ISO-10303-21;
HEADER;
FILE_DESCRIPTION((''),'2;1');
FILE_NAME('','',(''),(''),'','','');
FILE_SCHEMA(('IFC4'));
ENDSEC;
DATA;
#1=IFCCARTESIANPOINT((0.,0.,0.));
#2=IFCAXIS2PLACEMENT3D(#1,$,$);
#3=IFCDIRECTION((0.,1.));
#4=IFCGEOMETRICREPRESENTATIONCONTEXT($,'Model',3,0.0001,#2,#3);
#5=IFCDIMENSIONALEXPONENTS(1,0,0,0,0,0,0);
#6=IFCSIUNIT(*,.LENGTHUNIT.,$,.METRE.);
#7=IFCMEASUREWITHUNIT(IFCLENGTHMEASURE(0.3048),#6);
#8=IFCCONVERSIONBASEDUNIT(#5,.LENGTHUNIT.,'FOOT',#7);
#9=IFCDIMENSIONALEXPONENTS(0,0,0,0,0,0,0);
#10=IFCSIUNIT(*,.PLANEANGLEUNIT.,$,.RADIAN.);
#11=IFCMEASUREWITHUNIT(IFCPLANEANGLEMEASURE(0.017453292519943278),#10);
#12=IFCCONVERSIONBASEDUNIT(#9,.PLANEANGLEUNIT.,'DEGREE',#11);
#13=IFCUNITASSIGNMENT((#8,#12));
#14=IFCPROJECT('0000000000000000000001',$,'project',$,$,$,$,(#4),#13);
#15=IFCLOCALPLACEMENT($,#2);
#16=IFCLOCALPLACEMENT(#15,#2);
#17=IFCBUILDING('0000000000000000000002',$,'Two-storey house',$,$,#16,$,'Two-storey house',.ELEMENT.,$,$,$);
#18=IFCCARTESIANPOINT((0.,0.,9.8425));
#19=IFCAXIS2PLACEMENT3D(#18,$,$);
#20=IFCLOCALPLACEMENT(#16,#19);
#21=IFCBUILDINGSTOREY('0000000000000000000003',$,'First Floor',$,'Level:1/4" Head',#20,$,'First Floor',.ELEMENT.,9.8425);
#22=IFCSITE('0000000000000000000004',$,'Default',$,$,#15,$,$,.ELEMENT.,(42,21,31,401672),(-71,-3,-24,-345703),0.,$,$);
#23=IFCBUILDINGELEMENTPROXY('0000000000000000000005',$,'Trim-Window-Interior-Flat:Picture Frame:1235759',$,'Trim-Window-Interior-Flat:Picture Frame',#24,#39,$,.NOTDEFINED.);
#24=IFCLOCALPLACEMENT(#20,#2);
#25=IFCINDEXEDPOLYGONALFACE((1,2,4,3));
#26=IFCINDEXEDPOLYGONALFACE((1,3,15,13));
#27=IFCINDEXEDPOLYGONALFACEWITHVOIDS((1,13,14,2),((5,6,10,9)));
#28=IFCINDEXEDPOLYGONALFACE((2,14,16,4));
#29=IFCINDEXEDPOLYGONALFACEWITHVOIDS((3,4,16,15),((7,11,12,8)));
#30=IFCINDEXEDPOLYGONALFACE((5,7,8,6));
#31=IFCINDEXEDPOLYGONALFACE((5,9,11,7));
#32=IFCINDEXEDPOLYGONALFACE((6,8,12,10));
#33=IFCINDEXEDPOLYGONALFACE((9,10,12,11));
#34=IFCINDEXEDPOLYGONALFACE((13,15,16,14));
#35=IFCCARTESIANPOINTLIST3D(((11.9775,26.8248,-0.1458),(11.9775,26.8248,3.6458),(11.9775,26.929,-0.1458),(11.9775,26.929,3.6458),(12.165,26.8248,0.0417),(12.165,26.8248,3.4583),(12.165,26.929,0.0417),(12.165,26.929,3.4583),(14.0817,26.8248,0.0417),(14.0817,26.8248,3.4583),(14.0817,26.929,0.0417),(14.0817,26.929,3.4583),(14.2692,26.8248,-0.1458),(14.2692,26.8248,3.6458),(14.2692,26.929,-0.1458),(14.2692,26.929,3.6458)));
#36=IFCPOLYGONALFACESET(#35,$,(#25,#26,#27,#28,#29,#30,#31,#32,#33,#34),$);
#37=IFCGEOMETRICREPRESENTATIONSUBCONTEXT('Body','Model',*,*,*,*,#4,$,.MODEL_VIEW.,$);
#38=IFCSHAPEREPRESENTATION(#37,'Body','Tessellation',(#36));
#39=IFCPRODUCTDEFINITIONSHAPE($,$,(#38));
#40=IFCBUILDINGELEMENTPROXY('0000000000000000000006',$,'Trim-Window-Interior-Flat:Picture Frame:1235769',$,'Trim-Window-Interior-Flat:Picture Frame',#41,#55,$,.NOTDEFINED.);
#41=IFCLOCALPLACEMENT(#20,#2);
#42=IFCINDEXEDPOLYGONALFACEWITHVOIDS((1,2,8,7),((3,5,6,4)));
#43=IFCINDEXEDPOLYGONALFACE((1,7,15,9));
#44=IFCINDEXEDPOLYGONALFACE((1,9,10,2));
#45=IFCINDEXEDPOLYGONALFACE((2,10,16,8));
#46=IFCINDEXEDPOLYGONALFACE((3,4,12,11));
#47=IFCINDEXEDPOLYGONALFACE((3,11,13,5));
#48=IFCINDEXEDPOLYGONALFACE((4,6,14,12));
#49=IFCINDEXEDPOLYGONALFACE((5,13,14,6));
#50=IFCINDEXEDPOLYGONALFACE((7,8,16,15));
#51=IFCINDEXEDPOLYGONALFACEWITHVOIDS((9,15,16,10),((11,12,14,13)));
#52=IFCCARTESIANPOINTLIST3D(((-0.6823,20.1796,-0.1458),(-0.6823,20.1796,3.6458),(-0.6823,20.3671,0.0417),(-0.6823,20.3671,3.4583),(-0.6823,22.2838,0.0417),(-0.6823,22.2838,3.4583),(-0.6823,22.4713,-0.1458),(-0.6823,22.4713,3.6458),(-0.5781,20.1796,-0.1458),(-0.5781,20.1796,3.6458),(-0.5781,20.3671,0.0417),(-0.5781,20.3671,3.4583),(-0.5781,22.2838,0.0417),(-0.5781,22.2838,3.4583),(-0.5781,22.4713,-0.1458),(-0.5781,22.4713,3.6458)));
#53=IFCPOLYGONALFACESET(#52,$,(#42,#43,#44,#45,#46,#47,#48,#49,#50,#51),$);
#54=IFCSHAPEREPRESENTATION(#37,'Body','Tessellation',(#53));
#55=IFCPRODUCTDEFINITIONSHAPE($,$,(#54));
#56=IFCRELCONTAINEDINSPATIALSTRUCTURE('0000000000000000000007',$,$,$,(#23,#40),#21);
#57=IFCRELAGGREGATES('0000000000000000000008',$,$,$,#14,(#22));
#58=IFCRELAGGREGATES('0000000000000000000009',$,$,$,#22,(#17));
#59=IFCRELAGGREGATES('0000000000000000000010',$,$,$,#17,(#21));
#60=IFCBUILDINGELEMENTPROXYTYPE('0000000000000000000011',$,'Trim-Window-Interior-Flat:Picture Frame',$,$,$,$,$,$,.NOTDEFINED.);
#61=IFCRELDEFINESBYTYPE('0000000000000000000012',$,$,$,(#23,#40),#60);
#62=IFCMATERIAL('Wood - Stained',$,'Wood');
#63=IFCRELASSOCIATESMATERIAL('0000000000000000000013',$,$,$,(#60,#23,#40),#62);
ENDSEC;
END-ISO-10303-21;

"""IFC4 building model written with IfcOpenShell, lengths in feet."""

from ifc_helpers import new_model, entity, si_unit, converted_unit, direction, frame, origin, place, context, subcontext, project, spatial, indexed_curve, outline, extrude, source, transform, mapped, material, type_object, type_shapes, element, save


model = new_model("IFC4")

# Units and contexts
model_context = context("Model", 3, precision=0.0001, world=origin(), true_north=direction((0.0, 1.0)))
body_context = subcontext(model_context, "Body", "Model", "MODEL_VIEW")
ifc_project = project(units=[converted_unit("LENGTHUNIT", "FOOT", entity("IfcLengthMeasure", 0.3048), si_unit("LENGTHUNIT", "METRE"), dimensions=[1, 0, 0, 0, 0, 0, 0]), converted_unit("PLANEANGLEUNIT", "DEGREE", entity("IfcPlaneAngleMeasure", 0.017453292519943278), si_unit("PLANEANGLEUNIT", "RADIAN"), dimensions=[0, 0, 0, 0, 0, 0, 0])], contexts=[model_context])

# Site, building, storey
site_placement = place(None, origin())
site = spatial("IfcSite", under=ifc_project, at=site_placement, Name="Default", CompositionType="ELEMENT", RefLatitude=(42, 21, 31, 401672), RefLongitude=(-71, -3, -24, -345703), RefElevation=0.0)
building_placement = place(site_placement, origin())
building = spatial("IfcBuilding", under=site, at=building_placement, Name="Two-storey house", LongName="Two-storey house", CompositionType="ELEMENT")
storey_placement = place(building_placement, frame((0.0, 0.0, 9.8425)))
storey = spatial("IfcBuildingStorey", under=building, at=storey_placement, Name="First Floor", ObjectType="Level:1/4\" Head", LongName="First Floor", CompositionType="ELEMENT", Elevation=9.8425)

# Shared definitions
ifc_material_1 = material(Name="Wood - Stained", Category="Wood")

# Building element proxies
building_element_proxy_type_1 = type_object("IfcBuildingElementProxyType", Name="Trim-Window-Interior-Flat:Picture Frame", PredefinedType="NOTDEFINED", material=ifc_material_1)
shared_shape_1 = source(origin(), body_context, "Body", "SweptSolid", [
    extrude(outline(indexed_curve([(-1.1458, -1.8958), (1.1458, -1.8958), (1.1458, 1.8958), (-1.1458, 1.8958), (-1.1458, -1.8958)], self_intersect=False), holes=[indexed_curve([(-0.9583, -1.7083), (-0.9583, 1.7083), (0.9583, 1.7083), (0.9583, -1.7083), (-0.9583, -1.7083)], self_intersect=False)]), frame((0.0, -1.75, 0.0), z_axis=(0.0, 0.0, 1.0), x_axis=(-1.0, 0.0, 0.0)), (0.0, 0.0, 1.0), 0.1042),
])
type_shapes(building_element_proxy_type_1, [shared_shape_1])
for number, where, z_axis, x_axis, name in (
    (1, (13.1234, 26.8248, 3.5), (0.0, 1.0, 0.0), (-1.0, 0.0, 0.0), "Trim-Window-Interior-Flat:Picture Frame:1235759"),
    (2, (-0.5781, 21.3255, 3.5), (-1.0, 0.0, 0.0), (0.0, -1.0, 0.0), "Trim-Window-Interior-Flat:Picture Frame:1235769"),
):
    element("IfcBuildingElementProxy", number, at=place(storey_placement, frame(where, z_axis=z_axis, x_axis=x_axis)), inside=storey, type_object=building_element_proxy_type_1, material=ifc_material_1, Name=name, ObjectType="Trim-Window-Interior-Flat:Picture Frame", PredefinedType="NOTDEFINED", context=body_context, shape_type="MappedRepresentation", body=[
        mapped(shared_shape_1, transform((0.0, 0.0, 0.0), scale=1.0)),
    ])

save(model, "model.ifc")
